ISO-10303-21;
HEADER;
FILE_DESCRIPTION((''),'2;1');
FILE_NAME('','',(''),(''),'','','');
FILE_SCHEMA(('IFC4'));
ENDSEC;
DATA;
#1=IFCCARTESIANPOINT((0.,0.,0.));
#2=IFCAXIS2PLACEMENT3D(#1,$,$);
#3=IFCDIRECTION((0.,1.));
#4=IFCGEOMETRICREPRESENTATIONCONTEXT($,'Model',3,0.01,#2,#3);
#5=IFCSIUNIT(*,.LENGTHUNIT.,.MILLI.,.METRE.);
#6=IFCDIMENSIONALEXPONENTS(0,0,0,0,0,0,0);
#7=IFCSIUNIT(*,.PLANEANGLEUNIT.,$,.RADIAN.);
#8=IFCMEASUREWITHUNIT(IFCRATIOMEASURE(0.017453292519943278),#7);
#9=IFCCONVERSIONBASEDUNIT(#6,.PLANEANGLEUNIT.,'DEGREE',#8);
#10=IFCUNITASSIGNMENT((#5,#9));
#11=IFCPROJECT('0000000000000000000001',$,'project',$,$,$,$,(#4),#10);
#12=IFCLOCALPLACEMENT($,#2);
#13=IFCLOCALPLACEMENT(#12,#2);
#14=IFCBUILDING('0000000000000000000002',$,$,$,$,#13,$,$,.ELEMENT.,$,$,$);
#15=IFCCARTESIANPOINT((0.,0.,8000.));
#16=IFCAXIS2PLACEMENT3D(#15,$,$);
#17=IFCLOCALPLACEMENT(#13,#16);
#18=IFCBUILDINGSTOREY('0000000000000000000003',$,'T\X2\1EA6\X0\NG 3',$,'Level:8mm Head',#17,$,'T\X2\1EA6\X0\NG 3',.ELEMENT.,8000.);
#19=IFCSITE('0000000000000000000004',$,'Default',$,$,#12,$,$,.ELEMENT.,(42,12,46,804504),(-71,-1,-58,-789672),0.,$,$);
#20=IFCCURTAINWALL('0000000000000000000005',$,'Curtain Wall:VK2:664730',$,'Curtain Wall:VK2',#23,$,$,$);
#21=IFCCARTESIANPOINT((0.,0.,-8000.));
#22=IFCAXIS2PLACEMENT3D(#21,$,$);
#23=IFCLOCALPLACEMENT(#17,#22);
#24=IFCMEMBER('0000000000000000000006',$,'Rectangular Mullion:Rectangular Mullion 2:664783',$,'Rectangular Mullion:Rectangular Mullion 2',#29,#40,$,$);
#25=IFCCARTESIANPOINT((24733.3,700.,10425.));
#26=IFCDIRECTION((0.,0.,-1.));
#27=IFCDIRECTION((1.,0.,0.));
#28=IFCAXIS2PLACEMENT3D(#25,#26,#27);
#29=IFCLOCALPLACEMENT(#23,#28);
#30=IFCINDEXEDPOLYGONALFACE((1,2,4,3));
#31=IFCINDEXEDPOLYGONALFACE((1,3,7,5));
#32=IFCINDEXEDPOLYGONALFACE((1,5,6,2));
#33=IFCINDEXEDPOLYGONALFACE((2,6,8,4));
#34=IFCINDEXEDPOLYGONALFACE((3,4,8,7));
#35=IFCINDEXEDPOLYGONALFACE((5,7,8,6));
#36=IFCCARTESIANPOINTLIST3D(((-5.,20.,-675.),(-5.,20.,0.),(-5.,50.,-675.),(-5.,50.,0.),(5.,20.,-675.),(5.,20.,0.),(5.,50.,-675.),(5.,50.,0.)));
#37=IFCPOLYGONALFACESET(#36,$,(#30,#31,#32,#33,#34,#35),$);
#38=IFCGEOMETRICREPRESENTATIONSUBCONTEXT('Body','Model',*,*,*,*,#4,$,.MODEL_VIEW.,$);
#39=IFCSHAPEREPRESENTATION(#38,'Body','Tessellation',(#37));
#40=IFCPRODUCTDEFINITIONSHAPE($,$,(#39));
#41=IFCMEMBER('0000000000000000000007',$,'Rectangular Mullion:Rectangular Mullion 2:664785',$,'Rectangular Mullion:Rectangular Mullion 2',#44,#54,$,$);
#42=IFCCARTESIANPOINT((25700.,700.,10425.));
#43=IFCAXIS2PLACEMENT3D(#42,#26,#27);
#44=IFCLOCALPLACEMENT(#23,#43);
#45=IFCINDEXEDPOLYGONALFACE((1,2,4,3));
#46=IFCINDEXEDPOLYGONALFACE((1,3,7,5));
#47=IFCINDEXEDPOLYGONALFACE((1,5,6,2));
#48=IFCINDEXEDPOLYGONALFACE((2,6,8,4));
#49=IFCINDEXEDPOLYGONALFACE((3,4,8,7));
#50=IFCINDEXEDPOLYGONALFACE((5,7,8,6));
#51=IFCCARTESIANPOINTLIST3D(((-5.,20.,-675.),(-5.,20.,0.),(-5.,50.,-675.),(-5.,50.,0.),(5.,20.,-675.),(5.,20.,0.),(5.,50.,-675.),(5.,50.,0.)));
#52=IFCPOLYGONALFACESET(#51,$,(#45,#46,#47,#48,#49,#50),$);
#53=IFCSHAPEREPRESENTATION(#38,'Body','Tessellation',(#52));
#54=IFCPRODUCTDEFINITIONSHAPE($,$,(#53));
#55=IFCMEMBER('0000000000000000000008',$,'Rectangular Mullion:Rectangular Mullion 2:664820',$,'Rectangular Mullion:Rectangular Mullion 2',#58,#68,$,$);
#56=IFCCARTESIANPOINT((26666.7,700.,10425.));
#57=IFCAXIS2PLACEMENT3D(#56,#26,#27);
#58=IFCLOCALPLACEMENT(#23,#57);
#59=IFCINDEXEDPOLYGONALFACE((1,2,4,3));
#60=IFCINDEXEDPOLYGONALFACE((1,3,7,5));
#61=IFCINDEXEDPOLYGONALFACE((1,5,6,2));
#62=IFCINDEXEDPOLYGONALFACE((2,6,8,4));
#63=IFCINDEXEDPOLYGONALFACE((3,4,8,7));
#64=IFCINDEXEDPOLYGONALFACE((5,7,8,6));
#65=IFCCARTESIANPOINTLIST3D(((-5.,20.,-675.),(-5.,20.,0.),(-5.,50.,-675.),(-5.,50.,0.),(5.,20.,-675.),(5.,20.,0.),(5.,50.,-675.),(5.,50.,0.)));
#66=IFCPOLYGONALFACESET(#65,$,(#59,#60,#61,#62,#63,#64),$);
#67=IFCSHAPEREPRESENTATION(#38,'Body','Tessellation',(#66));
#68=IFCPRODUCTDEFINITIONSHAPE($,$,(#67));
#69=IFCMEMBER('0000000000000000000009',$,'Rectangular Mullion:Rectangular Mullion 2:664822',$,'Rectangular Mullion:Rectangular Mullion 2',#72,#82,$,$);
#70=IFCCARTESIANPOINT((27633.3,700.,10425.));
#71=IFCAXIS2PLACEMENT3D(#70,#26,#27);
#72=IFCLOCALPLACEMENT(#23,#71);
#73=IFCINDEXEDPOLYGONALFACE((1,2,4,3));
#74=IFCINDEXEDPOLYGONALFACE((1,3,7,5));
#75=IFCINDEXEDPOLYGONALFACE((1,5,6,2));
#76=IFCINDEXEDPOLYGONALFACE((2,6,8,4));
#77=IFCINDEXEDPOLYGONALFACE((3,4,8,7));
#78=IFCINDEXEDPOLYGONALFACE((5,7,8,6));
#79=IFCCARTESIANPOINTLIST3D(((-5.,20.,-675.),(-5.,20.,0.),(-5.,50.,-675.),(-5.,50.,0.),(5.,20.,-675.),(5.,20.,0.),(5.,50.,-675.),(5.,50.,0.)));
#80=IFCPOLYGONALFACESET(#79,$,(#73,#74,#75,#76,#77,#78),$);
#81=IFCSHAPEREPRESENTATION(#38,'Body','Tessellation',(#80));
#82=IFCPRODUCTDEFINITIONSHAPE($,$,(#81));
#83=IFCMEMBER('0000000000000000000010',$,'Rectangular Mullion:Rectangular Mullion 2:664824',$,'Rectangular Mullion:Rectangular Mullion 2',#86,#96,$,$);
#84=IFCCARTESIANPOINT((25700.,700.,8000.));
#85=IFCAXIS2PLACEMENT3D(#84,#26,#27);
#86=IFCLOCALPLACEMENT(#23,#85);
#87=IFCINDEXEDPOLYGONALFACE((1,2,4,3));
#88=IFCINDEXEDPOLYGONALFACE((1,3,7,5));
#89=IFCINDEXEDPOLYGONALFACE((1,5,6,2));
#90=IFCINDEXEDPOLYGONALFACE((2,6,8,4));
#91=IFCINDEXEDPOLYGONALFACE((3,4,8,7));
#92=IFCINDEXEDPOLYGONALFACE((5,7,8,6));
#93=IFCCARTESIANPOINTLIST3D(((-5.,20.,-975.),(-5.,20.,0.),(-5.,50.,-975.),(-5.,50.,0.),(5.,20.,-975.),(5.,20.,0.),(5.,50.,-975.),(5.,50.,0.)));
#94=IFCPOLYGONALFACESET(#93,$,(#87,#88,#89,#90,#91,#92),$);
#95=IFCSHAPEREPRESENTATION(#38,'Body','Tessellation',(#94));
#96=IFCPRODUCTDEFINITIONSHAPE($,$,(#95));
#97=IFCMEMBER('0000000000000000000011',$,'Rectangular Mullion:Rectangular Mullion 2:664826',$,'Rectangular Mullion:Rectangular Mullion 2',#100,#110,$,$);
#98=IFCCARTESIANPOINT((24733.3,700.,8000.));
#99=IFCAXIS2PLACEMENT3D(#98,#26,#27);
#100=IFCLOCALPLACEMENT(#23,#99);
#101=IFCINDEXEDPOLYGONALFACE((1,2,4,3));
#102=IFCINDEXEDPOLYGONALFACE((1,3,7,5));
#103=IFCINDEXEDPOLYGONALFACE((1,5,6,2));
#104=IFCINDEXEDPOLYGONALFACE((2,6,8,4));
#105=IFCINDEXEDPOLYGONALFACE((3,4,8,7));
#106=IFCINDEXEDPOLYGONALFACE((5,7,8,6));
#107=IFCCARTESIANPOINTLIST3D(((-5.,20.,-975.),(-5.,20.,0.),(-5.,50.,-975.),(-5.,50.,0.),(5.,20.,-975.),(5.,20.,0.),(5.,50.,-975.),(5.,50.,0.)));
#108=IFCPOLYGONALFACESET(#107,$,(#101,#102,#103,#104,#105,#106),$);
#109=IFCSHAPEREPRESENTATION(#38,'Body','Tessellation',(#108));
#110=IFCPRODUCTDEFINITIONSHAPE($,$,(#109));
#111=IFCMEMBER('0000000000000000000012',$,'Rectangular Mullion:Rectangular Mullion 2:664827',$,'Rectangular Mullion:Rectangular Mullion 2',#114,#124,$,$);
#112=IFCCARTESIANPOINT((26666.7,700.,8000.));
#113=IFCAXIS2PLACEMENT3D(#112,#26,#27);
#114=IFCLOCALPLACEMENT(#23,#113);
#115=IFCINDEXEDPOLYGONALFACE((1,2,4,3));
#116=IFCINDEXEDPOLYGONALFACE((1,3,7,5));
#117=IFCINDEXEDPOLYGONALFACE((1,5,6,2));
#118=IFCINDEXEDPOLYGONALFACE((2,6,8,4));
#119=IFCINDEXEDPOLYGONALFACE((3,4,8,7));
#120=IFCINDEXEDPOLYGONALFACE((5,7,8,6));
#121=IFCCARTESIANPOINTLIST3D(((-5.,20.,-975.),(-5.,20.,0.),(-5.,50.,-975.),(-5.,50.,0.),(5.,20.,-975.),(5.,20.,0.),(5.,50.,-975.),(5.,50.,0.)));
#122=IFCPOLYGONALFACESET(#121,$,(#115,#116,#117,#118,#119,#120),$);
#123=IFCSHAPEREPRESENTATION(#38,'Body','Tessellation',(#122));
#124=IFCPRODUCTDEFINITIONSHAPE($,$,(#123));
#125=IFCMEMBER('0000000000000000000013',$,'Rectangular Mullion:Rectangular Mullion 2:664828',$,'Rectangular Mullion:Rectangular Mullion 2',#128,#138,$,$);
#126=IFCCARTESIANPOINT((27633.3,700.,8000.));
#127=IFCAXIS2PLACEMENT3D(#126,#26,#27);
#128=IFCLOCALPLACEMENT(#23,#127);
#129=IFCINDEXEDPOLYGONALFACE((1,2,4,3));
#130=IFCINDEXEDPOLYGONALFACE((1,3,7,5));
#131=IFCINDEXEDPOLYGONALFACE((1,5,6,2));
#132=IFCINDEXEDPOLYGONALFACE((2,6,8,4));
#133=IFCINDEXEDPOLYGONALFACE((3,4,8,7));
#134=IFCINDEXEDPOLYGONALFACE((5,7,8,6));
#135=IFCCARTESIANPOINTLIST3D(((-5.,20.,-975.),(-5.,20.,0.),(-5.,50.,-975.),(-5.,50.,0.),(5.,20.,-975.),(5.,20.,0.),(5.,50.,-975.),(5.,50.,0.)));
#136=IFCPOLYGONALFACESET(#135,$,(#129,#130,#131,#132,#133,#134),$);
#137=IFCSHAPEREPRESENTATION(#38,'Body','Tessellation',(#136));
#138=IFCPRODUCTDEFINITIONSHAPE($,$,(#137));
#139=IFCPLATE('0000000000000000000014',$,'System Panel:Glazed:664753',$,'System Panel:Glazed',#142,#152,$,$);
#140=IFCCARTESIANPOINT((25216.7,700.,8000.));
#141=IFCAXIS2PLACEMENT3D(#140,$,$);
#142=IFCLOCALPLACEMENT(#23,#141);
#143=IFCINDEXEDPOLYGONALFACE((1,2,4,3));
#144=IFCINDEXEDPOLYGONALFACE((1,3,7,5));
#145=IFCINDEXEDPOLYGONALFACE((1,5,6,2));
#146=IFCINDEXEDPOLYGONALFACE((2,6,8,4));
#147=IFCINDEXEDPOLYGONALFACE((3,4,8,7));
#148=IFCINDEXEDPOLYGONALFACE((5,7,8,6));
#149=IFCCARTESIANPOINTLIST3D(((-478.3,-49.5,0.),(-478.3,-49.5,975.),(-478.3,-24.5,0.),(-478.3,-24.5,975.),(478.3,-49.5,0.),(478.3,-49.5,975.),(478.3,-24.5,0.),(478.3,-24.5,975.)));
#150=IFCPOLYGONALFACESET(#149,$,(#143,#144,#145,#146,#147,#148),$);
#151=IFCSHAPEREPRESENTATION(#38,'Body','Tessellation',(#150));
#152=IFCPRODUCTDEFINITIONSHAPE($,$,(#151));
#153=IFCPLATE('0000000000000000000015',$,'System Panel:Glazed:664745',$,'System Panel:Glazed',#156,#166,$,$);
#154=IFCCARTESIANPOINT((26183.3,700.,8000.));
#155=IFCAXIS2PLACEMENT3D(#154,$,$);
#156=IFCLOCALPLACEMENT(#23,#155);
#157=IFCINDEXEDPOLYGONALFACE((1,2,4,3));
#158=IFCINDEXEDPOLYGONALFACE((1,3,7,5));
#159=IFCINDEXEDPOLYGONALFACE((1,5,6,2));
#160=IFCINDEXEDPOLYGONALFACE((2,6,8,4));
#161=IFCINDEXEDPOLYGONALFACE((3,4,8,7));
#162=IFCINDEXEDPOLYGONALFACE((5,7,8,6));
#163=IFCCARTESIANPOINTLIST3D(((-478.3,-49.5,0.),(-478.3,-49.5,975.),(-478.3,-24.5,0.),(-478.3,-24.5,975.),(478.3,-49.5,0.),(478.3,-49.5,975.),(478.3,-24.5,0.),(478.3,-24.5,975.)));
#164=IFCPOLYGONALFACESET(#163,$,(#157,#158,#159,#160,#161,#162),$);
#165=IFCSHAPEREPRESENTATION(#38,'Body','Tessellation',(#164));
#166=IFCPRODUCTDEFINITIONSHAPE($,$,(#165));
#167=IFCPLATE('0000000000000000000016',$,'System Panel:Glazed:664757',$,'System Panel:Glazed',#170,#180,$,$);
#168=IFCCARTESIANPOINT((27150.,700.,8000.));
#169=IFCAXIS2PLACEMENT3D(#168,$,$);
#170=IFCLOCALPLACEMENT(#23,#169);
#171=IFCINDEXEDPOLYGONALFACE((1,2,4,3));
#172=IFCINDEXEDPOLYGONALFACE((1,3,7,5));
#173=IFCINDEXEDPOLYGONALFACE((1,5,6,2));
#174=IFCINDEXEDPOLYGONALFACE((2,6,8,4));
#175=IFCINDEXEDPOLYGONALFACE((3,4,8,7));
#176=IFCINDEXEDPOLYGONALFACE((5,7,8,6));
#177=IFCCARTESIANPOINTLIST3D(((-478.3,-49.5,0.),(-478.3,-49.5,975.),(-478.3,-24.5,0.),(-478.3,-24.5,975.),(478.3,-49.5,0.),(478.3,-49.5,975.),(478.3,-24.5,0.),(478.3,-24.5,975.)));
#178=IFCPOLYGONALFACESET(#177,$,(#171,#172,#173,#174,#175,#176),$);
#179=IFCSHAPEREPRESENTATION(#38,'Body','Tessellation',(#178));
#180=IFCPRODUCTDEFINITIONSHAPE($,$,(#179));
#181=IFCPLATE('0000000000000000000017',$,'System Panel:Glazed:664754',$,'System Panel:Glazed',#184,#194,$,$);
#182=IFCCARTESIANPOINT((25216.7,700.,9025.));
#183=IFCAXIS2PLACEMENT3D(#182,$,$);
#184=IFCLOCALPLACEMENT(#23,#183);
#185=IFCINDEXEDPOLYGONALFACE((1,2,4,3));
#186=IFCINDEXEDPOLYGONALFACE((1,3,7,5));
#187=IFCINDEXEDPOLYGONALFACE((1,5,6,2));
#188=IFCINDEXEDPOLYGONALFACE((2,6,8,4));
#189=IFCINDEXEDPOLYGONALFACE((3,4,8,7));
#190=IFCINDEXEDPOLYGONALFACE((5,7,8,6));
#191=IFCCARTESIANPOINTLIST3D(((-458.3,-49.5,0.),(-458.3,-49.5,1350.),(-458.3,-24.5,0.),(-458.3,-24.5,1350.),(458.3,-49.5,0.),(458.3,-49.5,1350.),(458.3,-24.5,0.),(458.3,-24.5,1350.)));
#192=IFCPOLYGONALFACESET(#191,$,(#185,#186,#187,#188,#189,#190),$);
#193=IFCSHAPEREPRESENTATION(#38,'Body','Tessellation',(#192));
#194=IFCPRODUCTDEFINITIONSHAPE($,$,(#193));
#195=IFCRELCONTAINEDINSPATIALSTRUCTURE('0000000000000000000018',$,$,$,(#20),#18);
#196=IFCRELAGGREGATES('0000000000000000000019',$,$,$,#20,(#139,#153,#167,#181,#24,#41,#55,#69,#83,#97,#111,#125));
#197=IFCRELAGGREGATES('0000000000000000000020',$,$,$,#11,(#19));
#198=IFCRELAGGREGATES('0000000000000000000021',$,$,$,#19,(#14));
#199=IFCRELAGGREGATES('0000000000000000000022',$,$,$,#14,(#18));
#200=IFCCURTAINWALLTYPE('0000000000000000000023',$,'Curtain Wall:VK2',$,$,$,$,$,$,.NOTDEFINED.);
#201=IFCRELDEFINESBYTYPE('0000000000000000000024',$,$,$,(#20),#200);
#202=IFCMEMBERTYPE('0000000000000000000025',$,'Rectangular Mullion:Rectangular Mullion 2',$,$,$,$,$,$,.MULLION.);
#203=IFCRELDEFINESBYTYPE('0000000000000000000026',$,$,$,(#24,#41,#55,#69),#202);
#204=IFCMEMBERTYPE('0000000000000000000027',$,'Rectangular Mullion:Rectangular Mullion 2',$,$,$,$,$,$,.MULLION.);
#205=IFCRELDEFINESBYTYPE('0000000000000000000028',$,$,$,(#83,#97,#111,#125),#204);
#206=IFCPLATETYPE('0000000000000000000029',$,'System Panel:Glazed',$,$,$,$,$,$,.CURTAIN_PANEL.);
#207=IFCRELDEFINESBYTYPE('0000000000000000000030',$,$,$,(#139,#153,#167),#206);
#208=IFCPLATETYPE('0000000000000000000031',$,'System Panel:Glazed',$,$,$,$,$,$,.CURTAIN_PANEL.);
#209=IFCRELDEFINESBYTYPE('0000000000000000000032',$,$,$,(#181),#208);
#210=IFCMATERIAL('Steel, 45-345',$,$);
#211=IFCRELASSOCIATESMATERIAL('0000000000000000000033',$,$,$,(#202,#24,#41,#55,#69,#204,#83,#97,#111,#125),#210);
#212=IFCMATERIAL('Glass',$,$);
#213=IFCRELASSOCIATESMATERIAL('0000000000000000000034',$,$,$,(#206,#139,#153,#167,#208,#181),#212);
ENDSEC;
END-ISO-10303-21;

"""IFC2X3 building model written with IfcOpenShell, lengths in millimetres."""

from ifc_helpers import new_model, entity, si_unit, converted_unit, direction, frame, frame_2d, origin, origin_2d_with_axis, place, context, subcontext, project, spatial, rectangle, extrude, source, transform, mapped, material, type_object, type_shapes, element, aggregate, save


model = new_model("IFC2X3")

# Units and contexts
model_context = context("Model", 3, precision=0.01, world=origin(), true_north=direction((0.0, 1.0)))
body_context = subcontext(model_context, "Body", "Model", "MODEL_VIEW")
ifc_project = project(units=[si_unit("LENGTHUNIT", "METRE", prefix="MILLI"), converted_unit("PLANEANGLEUNIT", "DEGREE", entity("IfcRatioMeasure", 0.017453292519943278), si_unit("PLANEANGLEUNIT", "RADIAN"), dimensions=[0, 0, 0, 0, 0, 0, 0])], contexts=[model_context])

# Site, building, storey
site_placement = place(None, origin())
site = spatial("IfcSite", under=ifc_project, at=site_placement, Name="Default", CompositionType="ELEMENT", RefLatitude=(42, 12, 46, 804504), RefLongitude=(-71, -1, -58, -789672), RefElevation=0.0)
building_placement = place(site_placement, origin())
building = spatial("IfcBuilding", under=site, at=building_placement, CompositionType="ELEMENT")
storey_placement = place(building_placement, frame((0.0, 0.0, 8000.0)))
storey = spatial("IfcBuildingStorey", under=building, at=storey_placement, Name="TẦNG 3", ObjectType="Level:8mm Head", LongName="TẦNG 3", CompositionType="ELEMENT", Elevation=8000.0)

# Curtain wall, members, plates
curtain_wall_type = type_object("IfcCurtainWallType", Name="Curtain Wall:VK2", PredefinedType="NOTDEFINED")
curtain_wall_1_placement = place(storey_placement, frame((0.0, 0.0, -8000.0)))
curtain_wall_1 = element("IfcCurtainWall", 1, at=curtain_wall_1_placement, inside=storey, type_object=curtain_wall_type, Name="Curtain Wall:VK2:664730", ObjectType="Curtain Wall:VK2")
ifc_material_1 = material(Name="Steel, 45-345")
member_type_1 = type_object("IfcMemberType", Name="Rectangular Mullion:Rectangular Mullion 2", PredefinedType="MULLION", material=ifc_material_1)
shared_shape_1 = source(origin(), body_context, "Body", "SweptSolid", [
    extrude(rectangle(XDim=30.0, YDim=10.0, at=origin_2d_with_axis()), frame((0.0, 35.0, -675.0), z_axis=(0.0, 0.0, 1.0), x_axis=(0.0, -1.0, 0.0)), (0.0, 0.0, 1.0), 675.0),
])
type_shapes(member_type_1, [shared_shape_1])
member_1_placement = place(curtain_wall_1_placement, frame((24733.3, 700.0, 10425.0), z_axis=(0.0, 0.0, -1.0), x_axis=(1.0, 0.0, 0.0)))
member_1 = element("IfcMember", 2, at=member_1_placement, type_object=member_type_1, material=ifc_material_1, Name="Rectangular Mullion:Rectangular Mullion 2:664783", ObjectType="Rectangular Mullion:Rectangular Mullion 2", context=body_context, shape_type="MappedRepresentation", body=[
    mapped(shared_shape_1, transform((0.0, 0.0, 0.0), scale=1.0)),
])
member_2_placement = place(curtain_wall_1_placement, frame((25700.0, 700.0, 10425.0), z_axis=(0.0, 0.0, -1.0), x_axis=(1.0, 0.0, 0.0)))
member_2 = element("IfcMember", 3, at=member_2_placement, type_object=member_type_1, material=ifc_material_1, Name="Rectangular Mullion:Rectangular Mullion 2:664785", ObjectType="Rectangular Mullion:Rectangular Mullion 2", context=body_context, shape_type="MappedRepresentation", body=[
    mapped(shared_shape_1, transform((0.0, 0.0, 0.0), scale=1.0)),
])
member_3_placement = place(curtain_wall_1_placement, frame((26666.7, 700.0, 10425.0), z_axis=(0.0, 0.0, -1.0), x_axis=(1.0, 0.0, 0.0)))
member_3 = element("IfcMember", 4, at=member_3_placement, type_object=member_type_1, material=ifc_material_1, Name="Rectangular Mullion:Rectangular Mullion 2:664820", ObjectType="Rectangular Mullion:Rectangular Mullion 2", context=body_context, shape_type="MappedRepresentation", body=[
    mapped(shared_shape_1, transform((0.0, 0.0, 0.0), scale=1.0)),
])
member_4_placement = place(curtain_wall_1_placement, frame((27633.3, 700.0, 10425.0), z_axis=(0.0, 0.0, -1.0), x_axis=(1.0, 0.0, 0.0)))
member_4 = element("IfcMember", 5, at=member_4_placement, type_object=member_type_1, material=ifc_material_1, Name="Rectangular Mullion:Rectangular Mullion 2:664822", ObjectType="Rectangular Mullion:Rectangular Mullion 2", context=body_context, shape_type="MappedRepresentation", body=[
    mapped(shared_shape_1, transform((0.0, 0.0, 0.0), scale=1.0)),
])
member_type_2 = type_object("IfcMemberType", Name="Rectangular Mullion:Rectangular Mullion 2", PredefinedType="MULLION", material=ifc_material_1)
shared_shape_2 = source(origin(), body_context, "Body", "SweptSolid", [
    extrude(rectangle(XDim=30.0, YDim=10.0, at=origin_2d_with_axis()), frame((0.0, 35.0, -975.0), z_axis=(0.0, 0.0, 1.0), x_axis=(0.0, -1.0, 0.0)), (0.0, 0.0, 1.0), 975.0),
])
type_shapes(member_type_2, [shared_shape_2])
member_5_placement = place(curtain_wall_1_placement, frame((25700.0, 700.0, 8000.0), z_axis=(0.0, 0.0, -1.0), x_axis=(1.0, 0.0, 0.0)))
member_5 = element("IfcMember", 6, at=member_5_placement, type_object=member_type_2, material=ifc_material_1, Name="Rectangular Mullion:Rectangular Mullion 2:664824", ObjectType="Rectangular Mullion:Rectangular Mullion 2", context=body_context, shape_type="MappedRepresentation", body=[
    mapped(shared_shape_2, transform((0.0, 0.0, 0.0), scale=1.0)),
])
member_6_placement = place(curtain_wall_1_placement, frame((24733.3, 700.0, 8000.0), z_axis=(0.0, 0.0, -1.0), x_axis=(1.0, 0.0, 0.0)))
member_6 = element("IfcMember", 7, at=member_6_placement, type_object=member_type_2, material=ifc_material_1, Name="Rectangular Mullion:Rectangular Mullion 2:664826", ObjectType="Rectangular Mullion:Rectangular Mullion 2", context=body_context, shape_type="MappedRepresentation", body=[
    mapped(shared_shape_2, transform((0.0, 0.0, 0.0), scale=1.0)),
])
member_7_placement = place(curtain_wall_1_placement, frame((26666.7, 700.0, 8000.0), z_axis=(0.0, 0.0, -1.0), x_axis=(1.0, 0.0, 0.0)))
member_7 = element("IfcMember", 8, at=member_7_placement, type_object=member_type_2, material=ifc_material_1, Name="Rectangular Mullion:Rectangular Mullion 2:664827", ObjectType="Rectangular Mullion:Rectangular Mullion 2", context=body_context, shape_type="MappedRepresentation", body=[
    mapped(shared_shape_2, transform((0.0, 0.0, 0.0), scale=1.0)),
])
member_8_placement = place(curtain_wall_1_placement, frame((27633.3, 700.0, 8000.0), z_axis=(0.0, 0.0, -1.0), x_axis=(1.0, 0.0, 0.0)))
member_8 = element("IfcMember", 9, at=member_8_placement, type_object=member_type_2, material=ifc_material_1, Name="Rectangular Mullion:Rectangular Mullion 2:664828", ObjectType="Rectangular Mullion:Rectangular Mullion 2", context=body_context, shape_type="MappedRepresentation", body=[
    mapped(shared_shape_2, transform((0.0, 0.0, 0.0), scale=1.0)),
])
ifc_material_2 = material(Name="Glass")
plate_type_1 = type_object("IfcPlateType", Name="System Panel:Glazed", PredefinedType="CURTAIN_PANEL", material=ifc_material_2)
shared_shape_3 = source(origin(), body_context, "Body", "SweptSolid", [
    extrude(rectangle(XDim=25.0, YDim=956.7, at=frame_2d((0.0, 0.0), x_axis=(1.0, 0.0))), frame((0.0, -37.0, 0.0), z_axis=(0.0, 0.0, 1.0), x_axis=(0.0, 1.0, 0.0)), (0.0, 0.0, 1.0), 975.0),
])
type_shapes(plate_type_1, [shared_shape_3])
plate_1_placement = place(curtain_wall_1_placement, frame((25216.7, 700.0, 8000.0)))
plate_1 = element("IfcPlate", 10, at=plate_1_placement, type_object=plate_type_1, material=ifc_material_2, Name="System Panel:Glazed:664753", ObjectType="System Panel:Glazed", context=body_context, shape_type="MappedRepresentation", body=[
    mapped(shared_shape_3, transform((0.0, 0.0, 0.0), scale=1.0)),
])
plate_2_placement = place(curtain_wall_1_placement, frame((26183.3, 700.0, 8000.0)))
plate_2 = element("IfcPlate", 11, at=plate_2_placement, type_object=plate_type_1, material=ifc_material_2, Name="System Panel:Glazed:664745", ObjectType="System Panel:Glazed", context=body_context, shape_type="MappedRepresentation", body=[
    mapped(shared_shape_3, transform((0.0, 0.0, 0.0), scale=1.0)),
])
plate_3_placement = place(curtain_wall_1_placement, frame((27150.0, 700.0, 8000.0)))
plate_3 = element("IfcPlate", 12, at=plate_3_placement, type_object=plate_type_1, material=ifc_material_2, Name="System Panel:Glazed:664757", ObjectType="System Panel:Glazed", context=body_context, shape_type="MappedRepresentation", body=[
    mapped(shared_shape_3, transform((0.0, 0.0, 0.0), scale=1.0)),
])
plate_type_2 = type_object("IfcPlateType", Name="System Panel:Glazed", PredefinedType="CURTAIN_PANEL", material=ifc_material_2)
shared_shape_4 = source(origin(), body_context, "Body", "SweptSolid", [
    extrude(rectangle(XDim=25.0, YDim=916.7, at=frame_2d((0.0, 0.0), x_axis=(1.0, 0.0))), frame((0.0, -37.0, 0.0), z_axis=(0.0, 0.0, 1.0), x_axis=(0.0, 1.0, 0.0)), (0.0, 0.0, 1.0), 1350.0),
])
type_shapes(plate_type_2, [shared_shape_4])
plate_4_placement = place(curtain_wall_1_placement, frame((25216.7, 700.0, 9025.0)))
plate_4 = element("IfcPlate", 13, at=plate_4_placement, type_object=plate_type_2, material=ifc_material_2, Name="System Panel:Glazed:664754", ObjectType="System Panel:Glazed", context=body_context, shape_type="MappedRepresentation", body=[
    mapped(shared_shape_4, transform((0.0, 0.0, 0.0), scale=1.0)),
])
aggregate(curtain_wall_1, [plate_1, plate_2, plate_3, plate_4, member_1, member_2, member_3, member_4, member_5, member_6, member_7, member_8])

save(model, "model.ifc")
